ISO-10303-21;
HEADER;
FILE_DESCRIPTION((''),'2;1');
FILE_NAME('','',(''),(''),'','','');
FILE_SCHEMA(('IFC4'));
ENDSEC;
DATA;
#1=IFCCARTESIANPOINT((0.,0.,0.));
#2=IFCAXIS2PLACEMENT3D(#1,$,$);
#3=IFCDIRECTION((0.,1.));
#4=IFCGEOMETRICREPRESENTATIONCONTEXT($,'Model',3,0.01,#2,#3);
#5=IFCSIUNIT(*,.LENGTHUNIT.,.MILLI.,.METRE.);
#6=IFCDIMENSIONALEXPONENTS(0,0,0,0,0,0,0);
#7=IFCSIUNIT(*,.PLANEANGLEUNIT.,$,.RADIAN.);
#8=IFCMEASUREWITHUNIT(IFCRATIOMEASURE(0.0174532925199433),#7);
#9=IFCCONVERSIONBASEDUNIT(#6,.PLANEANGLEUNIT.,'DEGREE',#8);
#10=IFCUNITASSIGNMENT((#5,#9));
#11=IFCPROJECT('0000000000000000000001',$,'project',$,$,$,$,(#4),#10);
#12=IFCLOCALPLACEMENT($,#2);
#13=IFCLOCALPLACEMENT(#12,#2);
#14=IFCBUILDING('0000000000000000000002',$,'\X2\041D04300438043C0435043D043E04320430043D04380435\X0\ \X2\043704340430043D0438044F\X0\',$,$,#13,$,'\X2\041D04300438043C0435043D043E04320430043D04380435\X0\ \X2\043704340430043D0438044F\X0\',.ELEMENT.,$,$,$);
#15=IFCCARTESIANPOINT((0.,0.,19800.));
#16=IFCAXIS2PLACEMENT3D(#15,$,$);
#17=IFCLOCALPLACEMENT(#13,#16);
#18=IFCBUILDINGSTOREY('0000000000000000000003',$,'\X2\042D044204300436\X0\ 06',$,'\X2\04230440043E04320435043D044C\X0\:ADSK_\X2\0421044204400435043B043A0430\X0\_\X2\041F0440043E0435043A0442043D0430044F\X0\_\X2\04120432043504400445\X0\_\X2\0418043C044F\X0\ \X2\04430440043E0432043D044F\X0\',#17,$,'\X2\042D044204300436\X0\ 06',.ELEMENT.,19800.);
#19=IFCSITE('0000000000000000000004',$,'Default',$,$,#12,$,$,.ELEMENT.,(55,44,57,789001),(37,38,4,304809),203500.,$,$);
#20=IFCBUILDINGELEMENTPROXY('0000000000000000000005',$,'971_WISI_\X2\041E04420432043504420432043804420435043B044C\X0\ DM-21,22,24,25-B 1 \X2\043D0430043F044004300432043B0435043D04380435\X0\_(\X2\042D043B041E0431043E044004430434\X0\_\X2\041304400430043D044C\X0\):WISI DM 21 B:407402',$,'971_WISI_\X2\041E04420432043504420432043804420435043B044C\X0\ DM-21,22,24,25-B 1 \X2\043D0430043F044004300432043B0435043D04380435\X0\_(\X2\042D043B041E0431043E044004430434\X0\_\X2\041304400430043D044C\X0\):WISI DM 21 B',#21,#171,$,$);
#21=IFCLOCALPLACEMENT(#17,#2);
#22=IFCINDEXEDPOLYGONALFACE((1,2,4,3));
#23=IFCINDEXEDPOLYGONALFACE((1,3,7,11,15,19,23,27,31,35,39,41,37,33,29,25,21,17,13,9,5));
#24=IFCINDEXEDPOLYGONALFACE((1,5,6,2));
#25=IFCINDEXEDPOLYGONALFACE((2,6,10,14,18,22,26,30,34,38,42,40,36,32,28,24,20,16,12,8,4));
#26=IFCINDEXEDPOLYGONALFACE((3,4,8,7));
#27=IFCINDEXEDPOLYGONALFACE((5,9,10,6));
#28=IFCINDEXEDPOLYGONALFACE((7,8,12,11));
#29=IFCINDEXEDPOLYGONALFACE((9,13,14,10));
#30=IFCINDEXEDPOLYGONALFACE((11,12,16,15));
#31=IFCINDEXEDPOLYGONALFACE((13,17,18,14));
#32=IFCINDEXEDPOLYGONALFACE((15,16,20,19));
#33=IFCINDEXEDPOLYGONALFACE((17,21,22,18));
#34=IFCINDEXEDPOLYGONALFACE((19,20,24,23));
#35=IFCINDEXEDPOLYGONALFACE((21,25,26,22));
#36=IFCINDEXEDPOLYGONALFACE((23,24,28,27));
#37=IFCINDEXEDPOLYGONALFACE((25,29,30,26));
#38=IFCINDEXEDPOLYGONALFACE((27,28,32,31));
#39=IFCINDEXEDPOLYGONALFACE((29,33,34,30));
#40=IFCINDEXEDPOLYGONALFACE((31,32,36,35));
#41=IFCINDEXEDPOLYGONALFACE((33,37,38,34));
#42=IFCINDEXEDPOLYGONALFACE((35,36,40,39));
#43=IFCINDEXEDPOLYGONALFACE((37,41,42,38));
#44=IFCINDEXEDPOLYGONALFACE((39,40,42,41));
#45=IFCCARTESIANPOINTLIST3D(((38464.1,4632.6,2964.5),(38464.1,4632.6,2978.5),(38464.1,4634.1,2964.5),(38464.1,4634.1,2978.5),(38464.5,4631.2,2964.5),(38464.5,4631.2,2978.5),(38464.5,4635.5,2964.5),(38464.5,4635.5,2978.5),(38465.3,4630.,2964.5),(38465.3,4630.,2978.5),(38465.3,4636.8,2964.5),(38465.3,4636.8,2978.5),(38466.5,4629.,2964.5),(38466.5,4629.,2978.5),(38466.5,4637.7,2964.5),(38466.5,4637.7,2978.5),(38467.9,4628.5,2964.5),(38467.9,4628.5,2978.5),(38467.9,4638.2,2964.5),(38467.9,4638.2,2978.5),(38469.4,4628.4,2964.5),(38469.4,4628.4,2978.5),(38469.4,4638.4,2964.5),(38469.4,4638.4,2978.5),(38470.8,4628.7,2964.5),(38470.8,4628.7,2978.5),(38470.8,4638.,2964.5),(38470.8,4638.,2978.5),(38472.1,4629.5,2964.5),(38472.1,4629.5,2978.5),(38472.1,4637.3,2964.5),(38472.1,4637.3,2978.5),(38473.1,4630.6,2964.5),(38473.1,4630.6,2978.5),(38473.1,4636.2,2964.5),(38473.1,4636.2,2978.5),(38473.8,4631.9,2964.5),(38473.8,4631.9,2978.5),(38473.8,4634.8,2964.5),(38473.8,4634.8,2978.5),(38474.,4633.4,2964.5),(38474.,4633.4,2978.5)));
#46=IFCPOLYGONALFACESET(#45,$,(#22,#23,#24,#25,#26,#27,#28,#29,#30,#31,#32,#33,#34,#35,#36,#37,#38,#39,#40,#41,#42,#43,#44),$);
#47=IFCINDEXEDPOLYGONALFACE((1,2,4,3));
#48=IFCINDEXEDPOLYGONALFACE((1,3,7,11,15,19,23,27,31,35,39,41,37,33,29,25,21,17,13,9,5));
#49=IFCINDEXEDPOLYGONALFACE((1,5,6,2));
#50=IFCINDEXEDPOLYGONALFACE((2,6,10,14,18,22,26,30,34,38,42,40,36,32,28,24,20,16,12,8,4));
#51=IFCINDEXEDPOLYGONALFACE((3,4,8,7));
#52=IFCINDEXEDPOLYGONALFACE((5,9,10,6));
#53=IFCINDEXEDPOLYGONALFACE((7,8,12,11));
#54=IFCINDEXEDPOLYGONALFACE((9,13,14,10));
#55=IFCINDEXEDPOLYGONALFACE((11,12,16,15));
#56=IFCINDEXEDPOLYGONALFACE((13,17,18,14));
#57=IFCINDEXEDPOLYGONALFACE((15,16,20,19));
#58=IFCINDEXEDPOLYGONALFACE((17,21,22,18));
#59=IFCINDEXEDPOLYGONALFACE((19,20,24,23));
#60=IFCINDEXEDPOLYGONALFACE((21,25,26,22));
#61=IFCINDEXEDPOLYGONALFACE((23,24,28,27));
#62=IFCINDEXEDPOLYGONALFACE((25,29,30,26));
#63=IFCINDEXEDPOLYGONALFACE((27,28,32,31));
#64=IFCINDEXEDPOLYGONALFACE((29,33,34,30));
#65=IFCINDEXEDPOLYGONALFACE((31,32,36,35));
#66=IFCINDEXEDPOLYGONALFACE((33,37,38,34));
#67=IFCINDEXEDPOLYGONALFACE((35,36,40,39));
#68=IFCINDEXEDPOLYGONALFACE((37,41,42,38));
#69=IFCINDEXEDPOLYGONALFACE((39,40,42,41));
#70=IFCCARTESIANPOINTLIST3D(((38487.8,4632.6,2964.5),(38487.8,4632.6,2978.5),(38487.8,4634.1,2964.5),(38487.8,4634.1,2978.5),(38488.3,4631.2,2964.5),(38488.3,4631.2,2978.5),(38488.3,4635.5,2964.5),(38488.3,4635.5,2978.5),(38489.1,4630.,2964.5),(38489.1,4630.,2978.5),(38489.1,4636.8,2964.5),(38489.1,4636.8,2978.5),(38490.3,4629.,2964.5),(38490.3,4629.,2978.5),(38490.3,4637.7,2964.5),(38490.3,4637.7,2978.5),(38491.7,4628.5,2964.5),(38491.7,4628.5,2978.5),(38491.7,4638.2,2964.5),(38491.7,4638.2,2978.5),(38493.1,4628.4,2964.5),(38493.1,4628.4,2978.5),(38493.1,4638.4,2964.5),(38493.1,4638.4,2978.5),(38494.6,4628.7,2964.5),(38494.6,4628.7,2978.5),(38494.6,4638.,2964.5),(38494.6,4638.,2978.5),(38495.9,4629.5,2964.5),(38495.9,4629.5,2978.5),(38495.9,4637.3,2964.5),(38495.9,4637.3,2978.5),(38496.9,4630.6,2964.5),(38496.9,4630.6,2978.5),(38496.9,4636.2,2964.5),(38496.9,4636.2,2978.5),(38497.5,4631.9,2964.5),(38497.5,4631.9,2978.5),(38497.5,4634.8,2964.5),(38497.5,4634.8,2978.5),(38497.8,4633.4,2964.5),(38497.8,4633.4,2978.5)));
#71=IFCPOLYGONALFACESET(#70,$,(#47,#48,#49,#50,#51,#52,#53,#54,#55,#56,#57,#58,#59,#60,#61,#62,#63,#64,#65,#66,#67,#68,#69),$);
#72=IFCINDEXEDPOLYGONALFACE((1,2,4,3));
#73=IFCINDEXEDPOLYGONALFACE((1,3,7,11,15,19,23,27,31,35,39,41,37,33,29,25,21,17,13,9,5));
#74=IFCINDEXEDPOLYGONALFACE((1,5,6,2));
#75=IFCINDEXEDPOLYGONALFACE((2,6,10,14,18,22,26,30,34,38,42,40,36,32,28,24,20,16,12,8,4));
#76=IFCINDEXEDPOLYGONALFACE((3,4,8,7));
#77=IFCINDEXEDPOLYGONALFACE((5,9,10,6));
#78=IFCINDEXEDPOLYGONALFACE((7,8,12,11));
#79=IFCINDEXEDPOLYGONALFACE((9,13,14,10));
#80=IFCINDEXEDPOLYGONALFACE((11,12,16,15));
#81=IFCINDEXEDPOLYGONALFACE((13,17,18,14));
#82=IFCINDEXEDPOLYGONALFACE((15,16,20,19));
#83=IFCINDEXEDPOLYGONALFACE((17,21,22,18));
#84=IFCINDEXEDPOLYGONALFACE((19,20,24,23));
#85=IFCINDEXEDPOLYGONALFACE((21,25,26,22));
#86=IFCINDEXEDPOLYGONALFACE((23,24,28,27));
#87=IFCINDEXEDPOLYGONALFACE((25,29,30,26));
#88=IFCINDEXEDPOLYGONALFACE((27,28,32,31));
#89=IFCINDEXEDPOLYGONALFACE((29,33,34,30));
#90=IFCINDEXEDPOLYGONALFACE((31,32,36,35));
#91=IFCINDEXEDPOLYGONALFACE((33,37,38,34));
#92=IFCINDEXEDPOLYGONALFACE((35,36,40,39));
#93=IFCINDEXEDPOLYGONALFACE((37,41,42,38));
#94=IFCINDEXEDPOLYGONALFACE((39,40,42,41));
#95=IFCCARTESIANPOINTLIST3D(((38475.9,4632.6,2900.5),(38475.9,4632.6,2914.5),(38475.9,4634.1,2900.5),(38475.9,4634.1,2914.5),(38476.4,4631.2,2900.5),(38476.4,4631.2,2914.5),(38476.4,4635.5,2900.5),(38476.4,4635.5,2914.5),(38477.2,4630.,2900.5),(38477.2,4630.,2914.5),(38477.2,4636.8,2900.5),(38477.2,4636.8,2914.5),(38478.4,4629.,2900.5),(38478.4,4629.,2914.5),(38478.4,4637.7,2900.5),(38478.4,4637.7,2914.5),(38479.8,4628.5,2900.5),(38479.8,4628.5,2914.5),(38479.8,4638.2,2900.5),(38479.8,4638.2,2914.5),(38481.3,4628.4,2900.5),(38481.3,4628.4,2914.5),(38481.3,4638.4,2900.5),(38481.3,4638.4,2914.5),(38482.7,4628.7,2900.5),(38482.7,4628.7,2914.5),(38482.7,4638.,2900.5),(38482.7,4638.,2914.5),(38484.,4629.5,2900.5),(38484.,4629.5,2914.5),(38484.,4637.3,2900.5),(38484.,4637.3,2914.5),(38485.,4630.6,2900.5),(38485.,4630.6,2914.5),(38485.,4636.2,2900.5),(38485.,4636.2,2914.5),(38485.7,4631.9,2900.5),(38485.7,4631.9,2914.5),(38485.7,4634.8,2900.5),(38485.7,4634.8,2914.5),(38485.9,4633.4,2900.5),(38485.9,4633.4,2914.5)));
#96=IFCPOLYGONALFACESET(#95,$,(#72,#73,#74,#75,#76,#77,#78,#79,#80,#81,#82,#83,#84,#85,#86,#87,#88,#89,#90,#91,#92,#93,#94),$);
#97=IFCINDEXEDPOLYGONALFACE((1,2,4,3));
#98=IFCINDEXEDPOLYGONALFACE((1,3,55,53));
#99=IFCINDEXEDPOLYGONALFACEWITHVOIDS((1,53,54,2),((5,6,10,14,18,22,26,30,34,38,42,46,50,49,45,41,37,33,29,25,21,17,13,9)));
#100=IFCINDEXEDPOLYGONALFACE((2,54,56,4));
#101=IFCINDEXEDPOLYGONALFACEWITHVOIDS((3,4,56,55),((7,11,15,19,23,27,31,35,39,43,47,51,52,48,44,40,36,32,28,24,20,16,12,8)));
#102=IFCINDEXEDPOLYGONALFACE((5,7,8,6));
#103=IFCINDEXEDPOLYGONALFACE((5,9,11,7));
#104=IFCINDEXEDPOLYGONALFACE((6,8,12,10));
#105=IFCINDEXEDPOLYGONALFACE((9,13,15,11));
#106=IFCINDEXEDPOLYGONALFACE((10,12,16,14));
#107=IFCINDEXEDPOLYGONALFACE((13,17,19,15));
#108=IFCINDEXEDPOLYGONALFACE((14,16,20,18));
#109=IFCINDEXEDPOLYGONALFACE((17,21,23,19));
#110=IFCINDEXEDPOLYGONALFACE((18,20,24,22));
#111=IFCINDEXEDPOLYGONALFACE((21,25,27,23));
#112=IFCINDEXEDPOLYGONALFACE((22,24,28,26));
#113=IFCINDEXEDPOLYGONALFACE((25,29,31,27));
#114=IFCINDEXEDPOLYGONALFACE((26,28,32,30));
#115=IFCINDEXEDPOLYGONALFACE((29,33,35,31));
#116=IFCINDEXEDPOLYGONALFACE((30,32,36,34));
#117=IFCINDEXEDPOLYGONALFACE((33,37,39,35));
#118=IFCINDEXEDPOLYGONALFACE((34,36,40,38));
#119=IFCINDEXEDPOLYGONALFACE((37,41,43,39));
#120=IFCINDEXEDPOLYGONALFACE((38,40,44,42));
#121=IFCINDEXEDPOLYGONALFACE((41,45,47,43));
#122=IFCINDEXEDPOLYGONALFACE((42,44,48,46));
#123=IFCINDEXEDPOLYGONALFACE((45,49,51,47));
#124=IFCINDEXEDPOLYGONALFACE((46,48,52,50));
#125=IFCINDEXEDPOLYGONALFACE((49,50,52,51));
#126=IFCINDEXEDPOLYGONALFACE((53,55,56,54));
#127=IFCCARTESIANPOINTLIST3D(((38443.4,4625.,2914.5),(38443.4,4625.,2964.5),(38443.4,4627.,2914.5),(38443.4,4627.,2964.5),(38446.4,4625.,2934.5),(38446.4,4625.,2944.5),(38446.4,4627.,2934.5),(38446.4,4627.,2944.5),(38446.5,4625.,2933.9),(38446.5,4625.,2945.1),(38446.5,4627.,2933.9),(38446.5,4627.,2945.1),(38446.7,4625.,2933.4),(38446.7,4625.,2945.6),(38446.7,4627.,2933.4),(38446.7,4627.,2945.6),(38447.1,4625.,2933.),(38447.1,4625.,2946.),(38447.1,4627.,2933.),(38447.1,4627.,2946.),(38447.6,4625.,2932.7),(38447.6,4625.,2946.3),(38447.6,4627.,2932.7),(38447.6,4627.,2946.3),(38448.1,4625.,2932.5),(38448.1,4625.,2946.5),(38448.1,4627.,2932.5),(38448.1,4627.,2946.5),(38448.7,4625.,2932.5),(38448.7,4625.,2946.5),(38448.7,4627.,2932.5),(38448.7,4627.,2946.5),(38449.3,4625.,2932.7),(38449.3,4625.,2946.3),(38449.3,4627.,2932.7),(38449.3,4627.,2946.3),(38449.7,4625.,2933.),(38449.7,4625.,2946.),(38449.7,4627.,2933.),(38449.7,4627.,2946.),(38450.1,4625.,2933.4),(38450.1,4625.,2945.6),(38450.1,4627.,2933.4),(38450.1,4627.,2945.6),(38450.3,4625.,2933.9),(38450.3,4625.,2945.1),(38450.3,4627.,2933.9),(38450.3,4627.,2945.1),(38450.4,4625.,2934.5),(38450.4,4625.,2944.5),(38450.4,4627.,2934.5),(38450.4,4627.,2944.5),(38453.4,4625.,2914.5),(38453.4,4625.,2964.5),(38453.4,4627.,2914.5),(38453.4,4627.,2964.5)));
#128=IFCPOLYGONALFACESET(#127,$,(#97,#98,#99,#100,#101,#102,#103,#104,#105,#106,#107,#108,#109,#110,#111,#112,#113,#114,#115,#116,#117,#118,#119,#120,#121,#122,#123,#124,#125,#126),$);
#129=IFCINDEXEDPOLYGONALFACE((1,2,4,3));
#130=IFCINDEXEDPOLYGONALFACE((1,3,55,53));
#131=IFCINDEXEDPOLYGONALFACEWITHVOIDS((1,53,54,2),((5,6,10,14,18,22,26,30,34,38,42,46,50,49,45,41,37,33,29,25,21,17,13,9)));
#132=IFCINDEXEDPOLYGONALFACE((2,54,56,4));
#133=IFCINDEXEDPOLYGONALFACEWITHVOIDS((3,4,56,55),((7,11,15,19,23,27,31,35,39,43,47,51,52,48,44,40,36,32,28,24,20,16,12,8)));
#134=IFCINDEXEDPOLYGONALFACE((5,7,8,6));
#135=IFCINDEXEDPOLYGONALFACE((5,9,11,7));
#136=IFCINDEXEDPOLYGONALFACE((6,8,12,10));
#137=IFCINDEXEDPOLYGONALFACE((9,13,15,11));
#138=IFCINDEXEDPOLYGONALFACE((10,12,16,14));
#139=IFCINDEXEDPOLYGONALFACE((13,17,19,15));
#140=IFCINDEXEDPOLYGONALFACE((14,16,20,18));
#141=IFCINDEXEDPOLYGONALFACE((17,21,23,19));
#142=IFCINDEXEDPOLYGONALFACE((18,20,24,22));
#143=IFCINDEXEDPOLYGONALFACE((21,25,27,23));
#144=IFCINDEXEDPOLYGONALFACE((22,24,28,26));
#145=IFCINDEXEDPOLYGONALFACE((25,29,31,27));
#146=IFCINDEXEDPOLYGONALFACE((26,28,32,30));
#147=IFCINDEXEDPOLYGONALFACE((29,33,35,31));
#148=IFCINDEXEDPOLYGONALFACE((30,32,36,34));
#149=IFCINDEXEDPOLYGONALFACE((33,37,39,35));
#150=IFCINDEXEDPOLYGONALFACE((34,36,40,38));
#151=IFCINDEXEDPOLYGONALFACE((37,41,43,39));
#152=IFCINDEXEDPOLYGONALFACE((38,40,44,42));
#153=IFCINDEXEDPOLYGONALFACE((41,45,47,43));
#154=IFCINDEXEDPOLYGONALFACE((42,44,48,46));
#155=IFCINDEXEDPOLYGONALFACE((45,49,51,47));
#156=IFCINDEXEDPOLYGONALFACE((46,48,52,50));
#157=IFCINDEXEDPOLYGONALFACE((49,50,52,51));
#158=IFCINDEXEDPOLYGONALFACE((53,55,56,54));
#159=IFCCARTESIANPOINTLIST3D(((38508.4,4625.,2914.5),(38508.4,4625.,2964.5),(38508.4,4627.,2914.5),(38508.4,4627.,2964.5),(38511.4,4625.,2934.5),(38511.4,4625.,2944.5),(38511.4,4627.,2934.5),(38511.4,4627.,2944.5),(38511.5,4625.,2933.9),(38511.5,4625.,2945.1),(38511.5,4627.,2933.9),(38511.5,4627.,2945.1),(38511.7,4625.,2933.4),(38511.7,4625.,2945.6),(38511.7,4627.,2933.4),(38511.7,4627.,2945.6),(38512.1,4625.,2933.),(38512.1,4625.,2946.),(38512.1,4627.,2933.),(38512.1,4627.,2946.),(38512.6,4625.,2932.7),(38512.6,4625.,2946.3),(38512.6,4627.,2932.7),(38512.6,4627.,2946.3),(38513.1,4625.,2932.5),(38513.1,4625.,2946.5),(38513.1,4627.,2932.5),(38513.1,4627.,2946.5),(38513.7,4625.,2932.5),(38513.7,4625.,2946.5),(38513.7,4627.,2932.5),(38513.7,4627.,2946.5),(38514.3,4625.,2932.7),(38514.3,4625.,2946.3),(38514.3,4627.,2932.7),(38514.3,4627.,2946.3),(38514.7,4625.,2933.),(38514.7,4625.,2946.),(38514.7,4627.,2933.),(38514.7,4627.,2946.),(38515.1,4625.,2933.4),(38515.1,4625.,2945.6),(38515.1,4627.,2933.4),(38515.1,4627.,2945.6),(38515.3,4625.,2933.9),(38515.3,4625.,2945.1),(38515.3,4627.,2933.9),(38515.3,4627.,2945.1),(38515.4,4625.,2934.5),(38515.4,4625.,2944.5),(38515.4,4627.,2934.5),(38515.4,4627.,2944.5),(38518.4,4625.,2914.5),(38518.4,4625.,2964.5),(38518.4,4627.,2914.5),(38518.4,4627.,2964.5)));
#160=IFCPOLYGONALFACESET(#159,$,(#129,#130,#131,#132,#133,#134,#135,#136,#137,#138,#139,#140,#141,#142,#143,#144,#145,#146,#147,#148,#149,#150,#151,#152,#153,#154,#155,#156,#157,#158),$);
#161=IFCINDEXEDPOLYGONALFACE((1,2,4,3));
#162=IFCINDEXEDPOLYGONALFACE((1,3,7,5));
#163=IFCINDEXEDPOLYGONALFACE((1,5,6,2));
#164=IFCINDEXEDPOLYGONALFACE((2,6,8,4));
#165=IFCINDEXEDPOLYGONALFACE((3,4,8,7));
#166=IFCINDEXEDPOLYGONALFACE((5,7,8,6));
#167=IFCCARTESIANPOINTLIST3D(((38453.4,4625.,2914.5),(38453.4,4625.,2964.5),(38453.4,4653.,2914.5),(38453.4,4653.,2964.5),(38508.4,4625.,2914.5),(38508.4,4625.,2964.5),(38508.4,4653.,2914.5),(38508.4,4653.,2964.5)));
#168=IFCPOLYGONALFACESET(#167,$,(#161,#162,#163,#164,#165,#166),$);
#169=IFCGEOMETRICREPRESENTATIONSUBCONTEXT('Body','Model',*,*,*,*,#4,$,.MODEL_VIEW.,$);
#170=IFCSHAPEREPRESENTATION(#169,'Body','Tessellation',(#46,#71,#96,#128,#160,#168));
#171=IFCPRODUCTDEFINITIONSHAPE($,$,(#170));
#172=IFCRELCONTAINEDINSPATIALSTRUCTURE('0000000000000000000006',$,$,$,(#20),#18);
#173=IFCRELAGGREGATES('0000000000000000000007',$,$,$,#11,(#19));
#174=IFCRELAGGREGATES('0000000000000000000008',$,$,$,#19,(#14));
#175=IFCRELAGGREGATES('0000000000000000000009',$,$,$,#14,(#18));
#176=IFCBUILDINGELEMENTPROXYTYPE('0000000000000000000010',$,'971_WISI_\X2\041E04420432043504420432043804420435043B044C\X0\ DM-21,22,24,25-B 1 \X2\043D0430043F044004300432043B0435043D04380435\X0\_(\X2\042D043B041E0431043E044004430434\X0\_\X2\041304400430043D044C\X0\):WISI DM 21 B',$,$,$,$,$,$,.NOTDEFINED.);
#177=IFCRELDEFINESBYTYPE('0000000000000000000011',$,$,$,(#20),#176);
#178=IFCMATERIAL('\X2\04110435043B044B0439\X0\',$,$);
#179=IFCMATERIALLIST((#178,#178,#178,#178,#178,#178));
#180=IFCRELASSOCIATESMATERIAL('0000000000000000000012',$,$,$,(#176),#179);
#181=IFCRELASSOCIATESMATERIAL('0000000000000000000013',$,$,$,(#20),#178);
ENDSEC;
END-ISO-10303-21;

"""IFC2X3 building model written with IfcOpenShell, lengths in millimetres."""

from ifc_helpers import new_model, entity, si_unit, converted_unit, direction, frame, frame_2d, origin, place, context, subcontext, project, spatial, polyline, circle_curve, parameter, trimmed, segment, composite_curve, rectangle, circle, outline, extrude, source, transform, mapped, material, material_list, type_object, type_shapes, element, save


model = new_model("IFC2X3")

# Units and contexts
model_context = context("Model", 3, precision=0.01, world=origin(), true_north=direction((0.0, 1.0)))
body_context = subcontext(model_context, "Body", "Model", "MODEL_VIEW")
ifc_project = project(units=[si_unit("LENGTHUNIT", "METRE", prefix="MILLI"), converted_unit("PLANEANGLEUNIT", "DEGREE", entity("IfcRatioMeasure", 0.0174532925199433), si_unit("PLANEANGLEUNIT", "RADIAN"), dimensions=[0, 0, 0, 0, 0, 0, 0])], contexts=[model_context])

# Site, building, storey
site_placement = place(None, frame((0.0, 0.0, 0.0)))
site = spatial("IfcSite", under=ifc_project, at=site_placement, Name="Default", CompositionType="ELEMENT", RefLatitude=(55, 44, 57, 789001), RefLongitude=(37, 38, 4, 304809), RefElevation=203500.0)
building_placement = place(site_placement, origin())
building = spatial("IfcBuilding", under=site, at=building_placement, Name="Наименование здания", LongName="Наименование здания", CompositionType="ELEMENT")
storey_placement = place(building_placement, frame((0.0, 0.0, 19800.0)))
storey = spatial("IfcBuildingStorey", under=building, at=storey_placement, Name="Этаж 06", ObjectType="Уровень:ADSK_Стрелка_Проектная_Вверх_Имя уровня", LongName="Этаж 06", CompositionType="ELEMENT", Elevation=19800.0)

# Building element proxy
ifc_material_1 = material(Name="Белый")
ifc_material_list_1 = material_list([ifc_material_1, ifc_material_1, ifc_material_1, ifc_material_1, ifc_material_1, ifc_material_1])
building_element_proxy_type_1 = type_object("IfcBuildingElementProxyType", Name="971_WISI_Ответвитель DM-21,22,24,25-B 1 направление_(ЭлОборуд_Грань):WISI DM 21 B", PredefinedType="NOTDEFINED", material=ifc_material_list_1)
shared_shape_1 = source(origin(), body_context, "Body", "SweptSolid", [
    extrude(circle(Radius=5.0, at=frame_2d((0.0, 0.0), x_axis=(1.0, 0.0))), frame((11.9, 25.0, 8.4), z_axis=(0.0, 1.0, 0.0), x_axis=(-1.0, 0.0, 0.0)), (0.0, 0.0, 1.0), 14.0),
    extrude(circle(Radius=5.0, at=frame_2d((0.0, 0.0), x_axis=(1.0, 0.0))), frame((-11.8, 25.0, 8.4), z_axis=(0.0, 1.0, 0.0), x_axis=(-1.0, 0.0, 0.0)), (0.0, 0.0, 1.0), 14.0),
    extrude(circle(Radius=5.0, at=frame_2d((0.0, 0.0), x_axis=(1.0, 0.0))), frame((0.0, -39.0, 8.4), z_axis=(0.0, 1.0, 0.0), x_axis=(-1.0, 0.0, 0.0)), (0.0, 0.0, 1.0), 14.0),
    extrude(outline(polyline([(-5.0, -25.0), (5.0, -25.0), (5.0, 25.0), (-5.0, 25.0), (-5.0, -25.0)]), holes=[composite_curve([segment(polyline([(2.0, 5.0), (2.0, -5.0)]), True, "CONTINUOUS"), segment(trimmed(circle_curve(frame_2d((0.0, -5.0), x_axis=(-1.0, 0.0)), 2.0), [parameter(0.0)], [parameter(180.0)], True, "PARAMETER"), False, "CONTINUOUS"), segment(polyline([(-2.0, -5.0), (-2.0, 5.0)]), True, "CONTINUOUS"), segment(trimmed(circle_curve(frame_2d((0.0, 5.0), x_axis=(-1.0, 0.0)), 2.0), [parameter(180.0)], [parameter(0.0)], True, "PARAMETER"), False, "CONTINUOUS")], self_intersect=False)]), frame((32.5, 0.0, 0.0), z_axis=(0.0, 0.0, 1.0), x_axis=(-1.0, 0.0, 0.0)), (0.0, 0.0, 1.0), 2.0),
    extrude(outline(polyline([(-5.0, -25.0), (5.0, -25.0), (5.0, 25.0), (-5.0, 25.0), (-5.0, -25.0)]), holes=[composite_curve([segment(polyline([(-2.0, -5.0), (-2.0, 5.0)]), True, "CONTINUOUS"), segment(trimmed(circle_curve(frame_2d((0.0, 5.0), x_axis=(-1.0, 0.0)), 2.0), [parameter(180.0)], [parameter(0.0)], True, "PARAMETER"), False, "CONTINUOUS"), segment(polyline([(2.0, 5.0), (2.0, -5.0)]), True, "CONTINUOUS"), segment(trimmed(circle_curve(frame_2d((0.0, -5.0), x_axis=(-1.0, 0.0)), 2.0), [parameter(0.0)], [parameter(180.0)], True, "PARAMETER"), False, "CONTINUOUS")], self_intersect=False)]), frame((-32.5, 0.0, 0.0), z_axis=(0.0, 0.0, 1.0), x_axis=(-1.0, 0.0, 0.0)), (0.0, 0.0, 1.0), 2.0),
    extrude(rectangle(XDim=55.0, YDim=50.0, at=frame_2d((0.0, 0.0), x_axis=(1.0, 0.0))), frame((0.0, 0.0, 0.0), z_axis=(0.0, 0.0, 1.0), x_axis=(-1.0, 0.0, 0.0)), (0.0, 0.0, 1.0), 28.0),
])
type_shapes(building_element_proxy_type_1, [shared_shape_1])
for number, where, z_axis, x_axis, name in (
    (1, (38480.9, 4625.0, 2939.5), (0.0, 1.0, 0.0), (-1.0, 0.0, 0.0), "971_WISI_Ответвитель DM-21,22,24,25-B 1 направление_(ЭлОборуд_Грань):WISI DM 21 B:407402"),
):
    element("IfcBuildingElementProxy", number, at=place(storey_placement, frame(where, z_axis=z_axis, x_axis=x_axis)), inside=storey, type_object=building_element_proxy_type_1, material=ifc_material_1, Name=name, ObjectType="971_WISI_Ответвитель DM-21,22,24,25-B 1 направление_(ЭлОборуд_Грань):WISI DM 21 B", context=body_context, shape_type="MappedRepresentation", body=[
        mapped(shared_shape_1, transform((0.0, 0.0, 0.0), scale=1.0)),
    ])

save(model, "model.ifc")
